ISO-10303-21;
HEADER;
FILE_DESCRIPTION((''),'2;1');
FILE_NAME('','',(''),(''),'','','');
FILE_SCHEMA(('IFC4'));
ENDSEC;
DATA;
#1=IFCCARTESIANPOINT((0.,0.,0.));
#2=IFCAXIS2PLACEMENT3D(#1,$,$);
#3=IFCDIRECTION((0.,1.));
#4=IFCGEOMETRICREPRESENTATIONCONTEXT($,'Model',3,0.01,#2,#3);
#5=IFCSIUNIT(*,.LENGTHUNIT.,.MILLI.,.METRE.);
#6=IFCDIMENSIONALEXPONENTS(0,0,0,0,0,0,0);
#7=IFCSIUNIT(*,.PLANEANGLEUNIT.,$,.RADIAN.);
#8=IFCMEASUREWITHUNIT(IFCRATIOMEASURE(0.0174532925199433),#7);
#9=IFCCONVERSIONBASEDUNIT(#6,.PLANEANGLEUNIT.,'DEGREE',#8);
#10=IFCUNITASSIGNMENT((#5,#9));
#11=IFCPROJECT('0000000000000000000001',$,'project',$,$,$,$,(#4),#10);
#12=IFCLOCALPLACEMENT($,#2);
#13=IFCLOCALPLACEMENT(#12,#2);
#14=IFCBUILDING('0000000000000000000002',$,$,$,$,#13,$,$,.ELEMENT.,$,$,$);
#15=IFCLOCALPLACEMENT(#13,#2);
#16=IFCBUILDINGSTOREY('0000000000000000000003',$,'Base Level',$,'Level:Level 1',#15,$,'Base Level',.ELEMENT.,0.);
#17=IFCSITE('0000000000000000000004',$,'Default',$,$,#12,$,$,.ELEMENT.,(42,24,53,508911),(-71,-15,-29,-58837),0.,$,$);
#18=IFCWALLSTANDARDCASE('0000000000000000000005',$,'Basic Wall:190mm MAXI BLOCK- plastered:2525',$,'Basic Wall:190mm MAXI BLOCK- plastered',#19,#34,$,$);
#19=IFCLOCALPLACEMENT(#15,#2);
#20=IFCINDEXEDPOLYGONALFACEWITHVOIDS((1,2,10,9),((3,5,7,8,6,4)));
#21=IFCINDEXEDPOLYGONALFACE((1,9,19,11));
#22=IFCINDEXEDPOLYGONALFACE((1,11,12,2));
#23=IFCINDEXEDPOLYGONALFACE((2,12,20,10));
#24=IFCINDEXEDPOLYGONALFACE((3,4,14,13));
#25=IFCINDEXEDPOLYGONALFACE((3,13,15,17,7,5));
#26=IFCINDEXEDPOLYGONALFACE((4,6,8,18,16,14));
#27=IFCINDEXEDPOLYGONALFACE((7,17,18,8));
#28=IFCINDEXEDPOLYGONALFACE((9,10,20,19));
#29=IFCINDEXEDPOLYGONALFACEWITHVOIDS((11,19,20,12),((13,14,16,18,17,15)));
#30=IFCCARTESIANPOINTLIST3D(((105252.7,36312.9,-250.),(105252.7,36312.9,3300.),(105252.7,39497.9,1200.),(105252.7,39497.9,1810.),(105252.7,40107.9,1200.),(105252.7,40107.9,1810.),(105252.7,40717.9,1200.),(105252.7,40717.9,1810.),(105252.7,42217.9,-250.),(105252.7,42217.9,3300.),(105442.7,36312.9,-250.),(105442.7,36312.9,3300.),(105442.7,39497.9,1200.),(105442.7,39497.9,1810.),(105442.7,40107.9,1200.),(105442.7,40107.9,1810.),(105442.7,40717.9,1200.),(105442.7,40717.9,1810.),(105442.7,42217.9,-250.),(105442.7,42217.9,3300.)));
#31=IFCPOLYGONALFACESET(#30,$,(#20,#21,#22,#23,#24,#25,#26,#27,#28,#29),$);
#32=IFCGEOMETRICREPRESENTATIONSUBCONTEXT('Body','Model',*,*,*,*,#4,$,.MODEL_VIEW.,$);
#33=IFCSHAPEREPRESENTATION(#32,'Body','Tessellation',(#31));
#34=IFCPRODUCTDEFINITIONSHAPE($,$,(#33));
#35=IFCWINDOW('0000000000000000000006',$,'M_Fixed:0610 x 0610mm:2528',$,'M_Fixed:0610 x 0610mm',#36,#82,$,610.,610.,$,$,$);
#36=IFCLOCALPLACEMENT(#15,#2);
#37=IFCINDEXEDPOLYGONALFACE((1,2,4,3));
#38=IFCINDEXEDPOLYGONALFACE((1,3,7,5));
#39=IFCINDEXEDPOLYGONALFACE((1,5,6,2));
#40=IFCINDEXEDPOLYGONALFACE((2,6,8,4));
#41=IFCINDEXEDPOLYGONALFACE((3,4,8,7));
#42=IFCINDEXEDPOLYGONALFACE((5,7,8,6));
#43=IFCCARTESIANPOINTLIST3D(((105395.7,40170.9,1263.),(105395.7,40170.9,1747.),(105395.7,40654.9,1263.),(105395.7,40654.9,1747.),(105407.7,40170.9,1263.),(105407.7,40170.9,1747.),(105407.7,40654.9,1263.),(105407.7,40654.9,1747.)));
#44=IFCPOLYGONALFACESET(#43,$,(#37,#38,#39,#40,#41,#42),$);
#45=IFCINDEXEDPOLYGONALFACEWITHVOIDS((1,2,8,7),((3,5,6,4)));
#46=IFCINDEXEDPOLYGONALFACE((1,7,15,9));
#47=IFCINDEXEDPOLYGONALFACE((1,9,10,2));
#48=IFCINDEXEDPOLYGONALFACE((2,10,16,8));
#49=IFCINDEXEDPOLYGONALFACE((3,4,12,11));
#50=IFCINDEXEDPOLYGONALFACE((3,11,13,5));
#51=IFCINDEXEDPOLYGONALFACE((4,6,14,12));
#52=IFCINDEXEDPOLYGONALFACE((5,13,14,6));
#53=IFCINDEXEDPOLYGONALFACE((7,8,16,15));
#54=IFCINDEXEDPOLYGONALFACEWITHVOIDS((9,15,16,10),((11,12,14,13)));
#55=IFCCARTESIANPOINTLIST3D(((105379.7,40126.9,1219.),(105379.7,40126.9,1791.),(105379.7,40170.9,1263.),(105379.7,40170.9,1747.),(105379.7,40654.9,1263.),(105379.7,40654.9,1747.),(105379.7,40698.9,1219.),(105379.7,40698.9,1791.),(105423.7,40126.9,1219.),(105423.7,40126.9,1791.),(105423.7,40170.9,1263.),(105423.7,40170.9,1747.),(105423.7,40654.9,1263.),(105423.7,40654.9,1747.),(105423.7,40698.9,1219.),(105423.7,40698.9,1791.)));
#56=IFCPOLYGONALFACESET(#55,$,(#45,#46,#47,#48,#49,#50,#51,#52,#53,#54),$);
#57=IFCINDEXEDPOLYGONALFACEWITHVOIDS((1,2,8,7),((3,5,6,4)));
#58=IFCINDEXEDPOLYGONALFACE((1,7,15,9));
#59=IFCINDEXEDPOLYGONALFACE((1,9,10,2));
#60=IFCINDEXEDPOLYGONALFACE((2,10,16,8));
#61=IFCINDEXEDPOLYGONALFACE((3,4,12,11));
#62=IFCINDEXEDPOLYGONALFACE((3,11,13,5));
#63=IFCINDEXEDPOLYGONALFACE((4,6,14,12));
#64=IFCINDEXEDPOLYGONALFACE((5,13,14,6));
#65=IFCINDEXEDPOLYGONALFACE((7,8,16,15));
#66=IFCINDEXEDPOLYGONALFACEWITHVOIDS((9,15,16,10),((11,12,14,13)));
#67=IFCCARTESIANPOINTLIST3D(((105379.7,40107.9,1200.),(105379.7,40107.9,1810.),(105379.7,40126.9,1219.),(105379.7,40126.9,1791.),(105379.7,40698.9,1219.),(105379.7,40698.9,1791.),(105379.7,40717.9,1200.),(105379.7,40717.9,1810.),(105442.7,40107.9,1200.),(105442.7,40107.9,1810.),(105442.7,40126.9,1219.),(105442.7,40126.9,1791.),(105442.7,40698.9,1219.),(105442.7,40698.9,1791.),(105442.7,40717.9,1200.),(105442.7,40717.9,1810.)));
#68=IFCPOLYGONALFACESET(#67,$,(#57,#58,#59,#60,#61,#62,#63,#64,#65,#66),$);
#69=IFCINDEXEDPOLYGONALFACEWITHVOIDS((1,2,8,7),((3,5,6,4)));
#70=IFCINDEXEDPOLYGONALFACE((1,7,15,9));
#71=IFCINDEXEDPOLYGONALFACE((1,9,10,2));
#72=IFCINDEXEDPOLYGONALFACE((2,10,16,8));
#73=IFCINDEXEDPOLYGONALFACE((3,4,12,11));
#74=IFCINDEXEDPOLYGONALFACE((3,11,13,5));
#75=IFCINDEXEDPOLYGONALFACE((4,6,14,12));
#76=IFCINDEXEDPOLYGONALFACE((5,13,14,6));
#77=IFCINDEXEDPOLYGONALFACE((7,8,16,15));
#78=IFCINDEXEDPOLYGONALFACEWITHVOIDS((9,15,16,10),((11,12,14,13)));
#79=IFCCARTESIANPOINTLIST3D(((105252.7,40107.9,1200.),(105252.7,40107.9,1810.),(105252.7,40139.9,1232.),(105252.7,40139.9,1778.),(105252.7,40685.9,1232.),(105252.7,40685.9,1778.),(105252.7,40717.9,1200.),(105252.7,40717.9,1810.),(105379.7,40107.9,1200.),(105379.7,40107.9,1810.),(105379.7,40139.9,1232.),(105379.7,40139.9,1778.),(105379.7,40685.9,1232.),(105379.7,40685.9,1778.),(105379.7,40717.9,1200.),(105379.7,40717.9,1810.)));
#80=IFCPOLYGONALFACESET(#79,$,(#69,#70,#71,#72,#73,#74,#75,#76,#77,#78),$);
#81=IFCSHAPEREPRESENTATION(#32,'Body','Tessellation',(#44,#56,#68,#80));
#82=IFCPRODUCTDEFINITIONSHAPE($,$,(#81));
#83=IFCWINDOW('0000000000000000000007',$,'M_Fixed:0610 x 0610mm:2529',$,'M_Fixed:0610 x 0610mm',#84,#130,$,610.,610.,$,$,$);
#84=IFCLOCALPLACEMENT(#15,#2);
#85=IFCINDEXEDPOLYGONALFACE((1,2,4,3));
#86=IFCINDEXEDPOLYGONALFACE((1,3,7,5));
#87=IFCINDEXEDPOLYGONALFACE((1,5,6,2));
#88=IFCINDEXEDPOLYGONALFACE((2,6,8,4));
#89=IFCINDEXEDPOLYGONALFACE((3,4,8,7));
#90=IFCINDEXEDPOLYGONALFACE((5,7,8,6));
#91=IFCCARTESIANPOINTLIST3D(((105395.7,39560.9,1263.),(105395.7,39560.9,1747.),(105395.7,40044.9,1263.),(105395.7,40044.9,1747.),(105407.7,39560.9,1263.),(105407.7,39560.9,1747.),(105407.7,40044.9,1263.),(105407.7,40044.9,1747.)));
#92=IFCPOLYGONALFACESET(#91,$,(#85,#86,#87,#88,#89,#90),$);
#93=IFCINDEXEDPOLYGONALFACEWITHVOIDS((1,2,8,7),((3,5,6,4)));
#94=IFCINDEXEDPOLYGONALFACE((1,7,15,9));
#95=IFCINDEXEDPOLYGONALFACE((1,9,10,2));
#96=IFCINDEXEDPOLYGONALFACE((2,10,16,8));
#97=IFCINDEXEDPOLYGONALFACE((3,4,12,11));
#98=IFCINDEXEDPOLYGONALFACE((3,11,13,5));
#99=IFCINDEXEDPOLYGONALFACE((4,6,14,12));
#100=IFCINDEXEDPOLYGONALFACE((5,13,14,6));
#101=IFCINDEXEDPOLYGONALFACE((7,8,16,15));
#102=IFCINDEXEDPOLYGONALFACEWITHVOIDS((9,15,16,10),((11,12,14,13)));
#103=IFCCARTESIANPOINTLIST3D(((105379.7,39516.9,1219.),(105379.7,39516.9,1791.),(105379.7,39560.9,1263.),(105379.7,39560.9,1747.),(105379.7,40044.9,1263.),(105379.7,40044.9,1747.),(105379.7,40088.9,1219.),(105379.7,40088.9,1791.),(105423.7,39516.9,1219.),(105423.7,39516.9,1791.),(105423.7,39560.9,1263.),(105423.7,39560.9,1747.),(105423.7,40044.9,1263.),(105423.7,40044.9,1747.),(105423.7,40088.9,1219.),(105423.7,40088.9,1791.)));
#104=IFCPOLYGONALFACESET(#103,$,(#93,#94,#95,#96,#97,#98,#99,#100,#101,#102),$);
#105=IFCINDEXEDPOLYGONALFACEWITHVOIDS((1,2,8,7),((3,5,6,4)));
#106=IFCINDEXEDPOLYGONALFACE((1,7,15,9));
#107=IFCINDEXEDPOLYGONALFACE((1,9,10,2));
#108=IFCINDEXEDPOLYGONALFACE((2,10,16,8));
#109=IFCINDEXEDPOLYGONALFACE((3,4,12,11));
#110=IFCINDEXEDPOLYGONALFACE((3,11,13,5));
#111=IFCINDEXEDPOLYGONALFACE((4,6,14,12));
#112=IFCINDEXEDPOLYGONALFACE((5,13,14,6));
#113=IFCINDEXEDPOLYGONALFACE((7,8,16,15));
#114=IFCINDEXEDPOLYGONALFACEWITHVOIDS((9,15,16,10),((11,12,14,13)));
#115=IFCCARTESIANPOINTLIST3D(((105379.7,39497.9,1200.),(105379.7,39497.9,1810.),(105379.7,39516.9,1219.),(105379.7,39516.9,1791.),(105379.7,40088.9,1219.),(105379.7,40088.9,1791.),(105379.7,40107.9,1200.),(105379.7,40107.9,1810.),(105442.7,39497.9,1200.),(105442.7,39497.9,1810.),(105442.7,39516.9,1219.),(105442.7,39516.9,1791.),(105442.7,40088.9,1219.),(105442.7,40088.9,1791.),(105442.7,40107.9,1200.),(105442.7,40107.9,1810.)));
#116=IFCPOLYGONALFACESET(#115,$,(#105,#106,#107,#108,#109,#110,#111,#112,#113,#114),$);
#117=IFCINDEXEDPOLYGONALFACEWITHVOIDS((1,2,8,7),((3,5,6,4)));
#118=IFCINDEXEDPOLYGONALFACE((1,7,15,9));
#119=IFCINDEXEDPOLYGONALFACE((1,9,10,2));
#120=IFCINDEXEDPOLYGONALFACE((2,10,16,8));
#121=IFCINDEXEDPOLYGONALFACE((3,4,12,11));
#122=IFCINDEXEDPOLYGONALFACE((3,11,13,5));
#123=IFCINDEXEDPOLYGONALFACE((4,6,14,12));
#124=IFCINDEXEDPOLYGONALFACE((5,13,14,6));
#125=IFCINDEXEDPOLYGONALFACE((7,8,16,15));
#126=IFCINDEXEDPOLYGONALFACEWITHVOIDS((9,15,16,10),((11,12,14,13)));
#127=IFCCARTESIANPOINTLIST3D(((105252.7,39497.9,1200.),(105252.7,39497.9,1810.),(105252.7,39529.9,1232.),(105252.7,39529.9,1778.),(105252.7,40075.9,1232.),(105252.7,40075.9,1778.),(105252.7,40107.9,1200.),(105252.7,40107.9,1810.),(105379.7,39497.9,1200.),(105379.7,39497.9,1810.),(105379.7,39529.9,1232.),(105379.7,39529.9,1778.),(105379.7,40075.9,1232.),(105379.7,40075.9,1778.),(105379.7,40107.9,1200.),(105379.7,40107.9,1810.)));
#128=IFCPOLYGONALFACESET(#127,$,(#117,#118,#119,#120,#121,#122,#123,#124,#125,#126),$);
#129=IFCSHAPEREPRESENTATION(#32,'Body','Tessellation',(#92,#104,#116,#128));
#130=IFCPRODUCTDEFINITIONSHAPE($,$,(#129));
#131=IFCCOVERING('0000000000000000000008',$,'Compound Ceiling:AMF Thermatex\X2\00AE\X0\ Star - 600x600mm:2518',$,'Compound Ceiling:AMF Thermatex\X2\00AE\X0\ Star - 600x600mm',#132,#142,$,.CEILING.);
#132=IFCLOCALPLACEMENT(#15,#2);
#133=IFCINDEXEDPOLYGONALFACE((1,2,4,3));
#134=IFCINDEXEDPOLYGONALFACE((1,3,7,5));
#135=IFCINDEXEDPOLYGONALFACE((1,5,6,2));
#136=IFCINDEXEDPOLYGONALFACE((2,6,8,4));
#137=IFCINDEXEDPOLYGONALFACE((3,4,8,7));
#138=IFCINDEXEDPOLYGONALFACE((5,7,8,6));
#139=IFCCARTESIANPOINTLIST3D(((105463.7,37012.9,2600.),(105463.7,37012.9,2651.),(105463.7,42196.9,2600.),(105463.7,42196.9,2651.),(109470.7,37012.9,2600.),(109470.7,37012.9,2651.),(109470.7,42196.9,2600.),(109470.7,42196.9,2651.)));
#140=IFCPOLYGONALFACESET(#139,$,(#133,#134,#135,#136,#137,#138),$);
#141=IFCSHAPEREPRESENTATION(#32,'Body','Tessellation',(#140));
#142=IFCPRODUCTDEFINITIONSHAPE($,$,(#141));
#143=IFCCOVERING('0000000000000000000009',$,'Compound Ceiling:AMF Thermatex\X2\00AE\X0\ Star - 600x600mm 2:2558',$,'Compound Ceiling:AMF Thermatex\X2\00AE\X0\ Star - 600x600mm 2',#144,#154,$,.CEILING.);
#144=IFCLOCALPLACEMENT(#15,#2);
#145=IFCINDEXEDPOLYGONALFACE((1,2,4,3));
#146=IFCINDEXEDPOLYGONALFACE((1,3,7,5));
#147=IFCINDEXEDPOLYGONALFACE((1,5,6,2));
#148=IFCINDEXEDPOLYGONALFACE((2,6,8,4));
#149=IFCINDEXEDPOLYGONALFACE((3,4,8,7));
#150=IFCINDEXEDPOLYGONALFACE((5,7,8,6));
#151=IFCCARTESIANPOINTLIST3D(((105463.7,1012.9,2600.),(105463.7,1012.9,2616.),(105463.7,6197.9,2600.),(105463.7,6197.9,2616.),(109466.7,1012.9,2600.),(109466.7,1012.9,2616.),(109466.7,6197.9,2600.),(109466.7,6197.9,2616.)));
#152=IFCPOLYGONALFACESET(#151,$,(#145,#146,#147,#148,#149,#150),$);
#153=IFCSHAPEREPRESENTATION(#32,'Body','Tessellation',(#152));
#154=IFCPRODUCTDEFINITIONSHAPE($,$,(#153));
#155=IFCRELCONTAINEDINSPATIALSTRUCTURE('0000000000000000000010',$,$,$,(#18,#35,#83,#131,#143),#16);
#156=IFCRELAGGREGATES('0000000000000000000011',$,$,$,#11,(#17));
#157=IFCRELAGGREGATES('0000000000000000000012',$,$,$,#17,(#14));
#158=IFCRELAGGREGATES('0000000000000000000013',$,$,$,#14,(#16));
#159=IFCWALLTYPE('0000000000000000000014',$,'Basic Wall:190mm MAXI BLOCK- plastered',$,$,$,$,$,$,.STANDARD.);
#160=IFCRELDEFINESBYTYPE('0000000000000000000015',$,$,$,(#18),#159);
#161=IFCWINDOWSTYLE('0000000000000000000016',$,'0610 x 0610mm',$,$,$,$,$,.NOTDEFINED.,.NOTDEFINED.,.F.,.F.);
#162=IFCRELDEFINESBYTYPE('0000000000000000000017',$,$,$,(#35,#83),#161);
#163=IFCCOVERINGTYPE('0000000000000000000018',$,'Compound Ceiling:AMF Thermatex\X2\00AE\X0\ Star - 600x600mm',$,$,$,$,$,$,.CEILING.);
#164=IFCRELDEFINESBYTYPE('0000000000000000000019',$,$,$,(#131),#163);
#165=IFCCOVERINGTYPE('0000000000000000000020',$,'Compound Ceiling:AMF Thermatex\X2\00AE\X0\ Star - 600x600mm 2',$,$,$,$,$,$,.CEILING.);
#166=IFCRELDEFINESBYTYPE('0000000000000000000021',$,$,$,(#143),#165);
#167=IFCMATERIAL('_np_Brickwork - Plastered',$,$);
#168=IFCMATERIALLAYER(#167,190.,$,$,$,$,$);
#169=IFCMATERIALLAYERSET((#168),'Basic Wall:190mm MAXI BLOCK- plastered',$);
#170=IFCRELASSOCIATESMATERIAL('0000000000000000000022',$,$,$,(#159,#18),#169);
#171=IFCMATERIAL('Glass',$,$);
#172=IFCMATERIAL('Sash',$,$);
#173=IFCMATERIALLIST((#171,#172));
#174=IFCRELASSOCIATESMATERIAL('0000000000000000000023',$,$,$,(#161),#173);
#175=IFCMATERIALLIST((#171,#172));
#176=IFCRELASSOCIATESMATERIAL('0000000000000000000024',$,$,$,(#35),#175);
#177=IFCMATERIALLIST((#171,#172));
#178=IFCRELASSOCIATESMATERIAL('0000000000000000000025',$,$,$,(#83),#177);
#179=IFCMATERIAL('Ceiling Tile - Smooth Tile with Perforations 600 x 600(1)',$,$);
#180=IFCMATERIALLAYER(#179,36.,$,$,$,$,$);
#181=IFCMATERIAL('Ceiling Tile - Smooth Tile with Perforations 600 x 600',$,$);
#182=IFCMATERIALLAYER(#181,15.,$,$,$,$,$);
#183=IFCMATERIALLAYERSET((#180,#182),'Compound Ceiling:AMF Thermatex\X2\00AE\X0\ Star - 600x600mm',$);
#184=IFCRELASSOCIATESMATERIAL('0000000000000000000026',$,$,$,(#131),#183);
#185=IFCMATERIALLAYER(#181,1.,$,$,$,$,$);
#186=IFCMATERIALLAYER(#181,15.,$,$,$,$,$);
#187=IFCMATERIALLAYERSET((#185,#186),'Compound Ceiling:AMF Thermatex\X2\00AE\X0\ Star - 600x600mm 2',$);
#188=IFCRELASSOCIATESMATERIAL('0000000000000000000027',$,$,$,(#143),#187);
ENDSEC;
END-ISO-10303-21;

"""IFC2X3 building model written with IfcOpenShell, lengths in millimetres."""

from ifc_helpers import new_model, entity, si_unit, converted_unit, direction, frame, frame_2d, origin, place, context, subcontext, project, spatial, polyline, rectangle, outline, extrude, source, transform, mapped, material, material_list, layer, layer_set, layer_usage, type_object, type_shapes, element, fill, save


model = new_model("IFC2X3")

# Units and contexts
model_context = context("Model", 3, precision=0.01, world=origin(), true_north=direction((0.0, 1.0)))
body_context = subcontext(model_context, "Body", "Model", "MODEL_VIEW")
ifc_project = project(units=[si_unit("LENGTHUNIT", "METRE", prefix="MILLI"), converted_unit("PLANEANGLEUNIT", "DEGREE", entity("IfcRatioMeasure", 0.0174532925199433), si_unit("PLANEANGLEUNIT", "RADIAN"), dimensions=[0, 0, 0, 0, 0, 0, 0])], contexts=[model_context])

# Site, building, storey
site_placement = place(None, origin())
site = spatial("IfcSite", under=ifc_project, at=site_placement, Name="Default", CompositionType="ELEMENT", RefLatitude=(42, 24, 53, 508911), RefLongitude=(-71, -15, -29, -58837), RefElevation=0.0)
building_placement = place(site_placement, origin())
building = spatial("IfcBuilding", under=site, at=building_placement, CompositionType="ELEMENT")
storey_placement = place(building_placement, origin())
storey = spatial("IfcBuildingStorey", under=building, at=storey_placement, Name="Base Level", ObjectType="Level:Level 1", LongName="Base Level", CompositionType="ELEMENT", Elevation=0.0)

# Shared definitions
ifc_material_1 = material(Name="_np_Brickwork - Plastered")
ifc_layer_1 = layer(ifc_material_1, 190.0)
ifc_layer_set_1 = layer_set([ifc_layer_1], Name="Basic Wall:190mm MAXI BLOCK- plastered")
wall_type = type_object("IfcWallType", Name="Basic Wall:190mm MAXI BLOCK- plastered", PredefinedType="STANDARD", material=ifc_layer_set_1)
ifc_material_2 = material(Name="Glass")
ifc_material_3 = material(Name="Sash")
ifc_material_list_1 = material_list([ifc_material_2, ifc_material_3])
window_style = type_object("IfcWindowStyle", Name="0610 x 0610mm", ConstructionType="NOTDEFINED", OperationType="NOTDEFINED", ParameterTakesPrecedence=False, Sizeable=False, material=ifc_material_list_1)
shared_shape_1 = source(origin(), body_context, "Body", "SweptSolid", [
    extrude(rectangle(XDim=12.0, YDim=484.0, at=frame_2d((0.0, 0.0), x_axis=(1.0, 0.0))), frame((305.0, 149.0, 63.0), z_axis=(0.0, 0.0, 1.0), x_axis=(0.0, -1.0, 0.0)), (0.0, 0.0, 1.0), 484.0),
    extrude(outline(polyline([(-286.0, -286.0), (286.0, -286.0), (286.0, 286.0), (-286.0, 286.0), (-286.0, -286.0)]), holes=[polyline([(-242.0, -242.0), (-242.0, 242.0), (242.0, 242.0), (242.0, -242.0), (-242.0, -242.0)])]), frame((305.0, 127.0, 305.0), z_axis=(0.0, 1.0, 0.0), x_axis=(1.0, 0.0, 0.0)), (0.0, 0.0, 1.0), 44.0),
    extrude(outline(polyline([(-305.0, -305.0), (305.0, -305.0), (305.0, 305.0), (-305.0, 305.0), (-305.0, -305.0)]), holes=[polyline([(-286.0, -286.0), (-286.0, 286.0), (286.0, 286.0), (286.0, -286.0), (-286.0, -286.0)])]), frame((305.0, 127.0, 305.0), z_axis=(0.0, 1.0, 0.0), x_axis=(1.0, 0.0, 0.0)), (0.0, 0.0, 1.0), 63.0),
    extrude(outline(polyline([(-305.0, -305.0), (305.0, -305.0), (305.0, 305.0), (-305.0, 305.0), (-305.0, -305.0)]), holes=[polyline([(-273.0, -273.0), (-273.0, 273.0), (273.0, 273.0), (273.0, -273.0), (-273.0, -273.0)])]), frame((305.0, 0.0, 305.0), z_axis=(0.0, 1.0, 0.0), x_axis=(1.0, 0.0, 0.0)), (0.0, 0.0, 1.0), 127.0),
])
type_shapes(window_style, [shared_shape_1])

# Wall, openings, windows
ifc_layer_usage_1 = layer_usage(ifc_layer_set_1, "AXIS2", "NEGATIVE", 95.0)
wall_1_placement = place(building_placement, frame((105347.7, 36312.9, -250.0), z_axis=(0.0, 0.0, 1.0), x_axis=(0.0, 1.0, 0.0)))
wall_1 = element("IfcWallStandardCase", 1, at=wall_1_placement, inside=storey, type_object=wall_type, material=ifc_layer_usage_1, Name="Basic Wall:190mm MAXI BLOCK- plastered:2525", ObjectType="Basic Wall:190mm MAXI BLOCK- plastered", context=body_context, shape_type="SweptSolid", body=[
    extrude(rectangle(XDim=5905.0, YDim=190.0, at=frame_2d((2952.5, 0.0), x_axis=(-1.0, 0.0))), origin(), (0.0, 0.0, 1.0), 3550.0),
])
opening_1_placement = place(wall_1_placement, frame((4405.0, 95.0, 1450.0)))
opening_1 = element("IfcOpeningElement", 2, at=opening_1_placement, cuts=wall_1, ObjectType="Opening", context=body_context, shape_type="SweptSolid", body=[
    extrude(rectangle(XDim=610.0, YDim=610.0, at=frame_2d((305.0, 305.0), x_axis=(1.0, 0.0))), frame((0.0, 0.0, 0.0), z_axis=(0.0, -1.0, 0.0), x_axis=(0.0, 0.0, 1.0)), (0.0, 0.0, 1.0), 190.0),
])
opening_2_placement = place(wall_1_placement, frame((3795.0, 95.0, 1450.0)))
opening_2 = element("IfcOpeningElement", 3, at=opening_2_placement, cuts=wall_1, ObjectType="Opening", context=body_context, shape_type="SweptSolid", body=[
    extrude(rectangle(XDim=610.0, YDim=610.0, at=frame_2d((305.0, 305.0), x_axis=(1.0, 0.0))), frame((0.0, 0.0, 0.0), z_axis=(0.0, -1.0, 0.0), x_axis=(0.0, 0.0, 1.0)), (0.0, 0.0, 1.0), 190.0),
])
ifc_material_list_2 = material_list([ifc_material_2, ifc_material_3])
window_1_placement = place(opening_1_placement, frame((0.0, 0.0, 0.0), z_axis=(0.0, 0.0, 1.0), x_axis=(-1.0, 0.0, 0.0)))
window_1 = element("IfcWindow", 4, at=window_1_placement, inside=storey, type_object=window_style, material=ifc_material_list_2, Name="M_Fixed:0610 x 0610mm:2528", ObjectType="M_Fixed:0610 x 0610mm", OverallHeight=610.0, OverallWidth=610.0, context=body_context, shape_type="MappedRepresentation", body=[
    mapped(shared_shape_1, transform((0.0, 0.0, 0.0), scale=1.0)),
])
fill(opening_1, window_1)
ifc_material_list_3 = material_list([ifc_material_2, ifc_material_3])
window_2_placement = place(opening_2_placement, frame((0.0, 0.0, 0.0), z_axis=(0.0, 0.0, 1.0), x_axis=(-1.0, 0.0, 0.0)))
window_2 = element("IfcWindow", 5, at=window_2_placement, inside=storey, type_object=window_style, material=ifc_material_list_3, Name="M_Fixed:0610 x 0610mm:2529", ObjectType="M_Fixed:0610 x 0610mm", OverallHeight=610.0, OverallWidth=610.0, context=body_context, shape_type="MappedRepresentation", body=[
    mapped(shared_shape_1, transform((0.0, 0.0, 0.0), scale=1.0)),
])
fill(opening_2, window_2)

# Coverings
ifc_material_4 = material(Name="Ceiling Tile - Smooth Tile with Perforations 600 x 600(1)")
ifc_layer_2 = layer(ifc_material_4, 36.0)
ifc_material_5 = material(Name="Ceiling Tile - Smooth Tile with Perforations 600 x 600")
ifc_layer_3 = layer(ifc_material_5, 15.0)
ifc_layer_set_2 = layer_set([ifc_layer_2, ifc_layer_3], Name="Compound Ceiling:AMF Thermatex® Star - 600x600mm")
ifc_layer_usage_2 = layer_usage(ifc_layer_set_2, "AXIS3", "POSITIVE", 0.0)
covering_type_1 = type_object("IfcCoveringType", Name="Compound Ceiling:AMF Thermatex® Star - 600x600mm", PredefinedType="CEILING")
covering_1_placement = place(building_placement, origin())
element("IfcCovering", 6, at=covering_1_placement, inside=storey, type_object=covering_type_1, material=ifc_layer_usage_2, Name="Compound Ceiling:AMF Thermatex® Star - 600x600mm:2518", ObjectType="Compound Ceiling:AMF Thermatex® Star - 600x600mm", PredefinedType="CEILING", context=body_context, shape_type="SweptSolid", body=[
    extrude(rectangle(XDim=4007.0, YDim=5184.0, at=frame_2d((0.0, 0.0), x_axis=(1.0, 0.0))), frame((107467.2, 39604.9, 2600.0), z_axis=(0.0, 0.0, 1.0), x_axis=(-1.0, 0.0, 0.0)), (0.0, 0.0, 1.0), 51.0),
])
ifc_layer_4 = layer(ifc_material_5, 1.0)
ifc_layer_5 = layer(ifc_material_5, 15.0)
ifc_layer_set_3 = layer_set([ifc_layer_4, ifc_layer_5], Name="Compound Ceiling:AMF Thermatex® Star - 600x600mm 2")
ifc_layer_usage_3 = layer_usage(ifc_layer_set_3, "AXIS3", "POSITIVE", 0.0)
covering_type_2 = type_object("IfcCoveringType", Name="Compound Ceiling:AMF Thermatex® Star - 600x600mm 2", PredefinedType="CEILING")
covering_2_placement = place(building_placement, origin())
element("IfcCovering", 7, at=covering_2_placement, inside=storey, type_object=covering_type_2, material=ifc_layer_usage_3, Name="Compound Ceiling:AMF Thermatex® Star - 600x600mm 2:2558", ObjectType="Compound Ceiling:AMF Thermatex® Star - 600x600mm 2", PredefinedType="CEILING", context=body_context, shape_type="SweptSolid", body=[
    extrude(rectangle(XDim=4003.0, YDim=5185.0, at=frame_2d((0.0, 0.0), x_axis=(1.0, 0.0))), frame((107465.2, 3605.4, 2600.0), z_axis=(0.0, 0.0, 1.0), x_axis=(-1.0, 0.0, 0.0)), (0.0, 0.0, 1.0), 16.0),
])

save(model, "model.ifc")
